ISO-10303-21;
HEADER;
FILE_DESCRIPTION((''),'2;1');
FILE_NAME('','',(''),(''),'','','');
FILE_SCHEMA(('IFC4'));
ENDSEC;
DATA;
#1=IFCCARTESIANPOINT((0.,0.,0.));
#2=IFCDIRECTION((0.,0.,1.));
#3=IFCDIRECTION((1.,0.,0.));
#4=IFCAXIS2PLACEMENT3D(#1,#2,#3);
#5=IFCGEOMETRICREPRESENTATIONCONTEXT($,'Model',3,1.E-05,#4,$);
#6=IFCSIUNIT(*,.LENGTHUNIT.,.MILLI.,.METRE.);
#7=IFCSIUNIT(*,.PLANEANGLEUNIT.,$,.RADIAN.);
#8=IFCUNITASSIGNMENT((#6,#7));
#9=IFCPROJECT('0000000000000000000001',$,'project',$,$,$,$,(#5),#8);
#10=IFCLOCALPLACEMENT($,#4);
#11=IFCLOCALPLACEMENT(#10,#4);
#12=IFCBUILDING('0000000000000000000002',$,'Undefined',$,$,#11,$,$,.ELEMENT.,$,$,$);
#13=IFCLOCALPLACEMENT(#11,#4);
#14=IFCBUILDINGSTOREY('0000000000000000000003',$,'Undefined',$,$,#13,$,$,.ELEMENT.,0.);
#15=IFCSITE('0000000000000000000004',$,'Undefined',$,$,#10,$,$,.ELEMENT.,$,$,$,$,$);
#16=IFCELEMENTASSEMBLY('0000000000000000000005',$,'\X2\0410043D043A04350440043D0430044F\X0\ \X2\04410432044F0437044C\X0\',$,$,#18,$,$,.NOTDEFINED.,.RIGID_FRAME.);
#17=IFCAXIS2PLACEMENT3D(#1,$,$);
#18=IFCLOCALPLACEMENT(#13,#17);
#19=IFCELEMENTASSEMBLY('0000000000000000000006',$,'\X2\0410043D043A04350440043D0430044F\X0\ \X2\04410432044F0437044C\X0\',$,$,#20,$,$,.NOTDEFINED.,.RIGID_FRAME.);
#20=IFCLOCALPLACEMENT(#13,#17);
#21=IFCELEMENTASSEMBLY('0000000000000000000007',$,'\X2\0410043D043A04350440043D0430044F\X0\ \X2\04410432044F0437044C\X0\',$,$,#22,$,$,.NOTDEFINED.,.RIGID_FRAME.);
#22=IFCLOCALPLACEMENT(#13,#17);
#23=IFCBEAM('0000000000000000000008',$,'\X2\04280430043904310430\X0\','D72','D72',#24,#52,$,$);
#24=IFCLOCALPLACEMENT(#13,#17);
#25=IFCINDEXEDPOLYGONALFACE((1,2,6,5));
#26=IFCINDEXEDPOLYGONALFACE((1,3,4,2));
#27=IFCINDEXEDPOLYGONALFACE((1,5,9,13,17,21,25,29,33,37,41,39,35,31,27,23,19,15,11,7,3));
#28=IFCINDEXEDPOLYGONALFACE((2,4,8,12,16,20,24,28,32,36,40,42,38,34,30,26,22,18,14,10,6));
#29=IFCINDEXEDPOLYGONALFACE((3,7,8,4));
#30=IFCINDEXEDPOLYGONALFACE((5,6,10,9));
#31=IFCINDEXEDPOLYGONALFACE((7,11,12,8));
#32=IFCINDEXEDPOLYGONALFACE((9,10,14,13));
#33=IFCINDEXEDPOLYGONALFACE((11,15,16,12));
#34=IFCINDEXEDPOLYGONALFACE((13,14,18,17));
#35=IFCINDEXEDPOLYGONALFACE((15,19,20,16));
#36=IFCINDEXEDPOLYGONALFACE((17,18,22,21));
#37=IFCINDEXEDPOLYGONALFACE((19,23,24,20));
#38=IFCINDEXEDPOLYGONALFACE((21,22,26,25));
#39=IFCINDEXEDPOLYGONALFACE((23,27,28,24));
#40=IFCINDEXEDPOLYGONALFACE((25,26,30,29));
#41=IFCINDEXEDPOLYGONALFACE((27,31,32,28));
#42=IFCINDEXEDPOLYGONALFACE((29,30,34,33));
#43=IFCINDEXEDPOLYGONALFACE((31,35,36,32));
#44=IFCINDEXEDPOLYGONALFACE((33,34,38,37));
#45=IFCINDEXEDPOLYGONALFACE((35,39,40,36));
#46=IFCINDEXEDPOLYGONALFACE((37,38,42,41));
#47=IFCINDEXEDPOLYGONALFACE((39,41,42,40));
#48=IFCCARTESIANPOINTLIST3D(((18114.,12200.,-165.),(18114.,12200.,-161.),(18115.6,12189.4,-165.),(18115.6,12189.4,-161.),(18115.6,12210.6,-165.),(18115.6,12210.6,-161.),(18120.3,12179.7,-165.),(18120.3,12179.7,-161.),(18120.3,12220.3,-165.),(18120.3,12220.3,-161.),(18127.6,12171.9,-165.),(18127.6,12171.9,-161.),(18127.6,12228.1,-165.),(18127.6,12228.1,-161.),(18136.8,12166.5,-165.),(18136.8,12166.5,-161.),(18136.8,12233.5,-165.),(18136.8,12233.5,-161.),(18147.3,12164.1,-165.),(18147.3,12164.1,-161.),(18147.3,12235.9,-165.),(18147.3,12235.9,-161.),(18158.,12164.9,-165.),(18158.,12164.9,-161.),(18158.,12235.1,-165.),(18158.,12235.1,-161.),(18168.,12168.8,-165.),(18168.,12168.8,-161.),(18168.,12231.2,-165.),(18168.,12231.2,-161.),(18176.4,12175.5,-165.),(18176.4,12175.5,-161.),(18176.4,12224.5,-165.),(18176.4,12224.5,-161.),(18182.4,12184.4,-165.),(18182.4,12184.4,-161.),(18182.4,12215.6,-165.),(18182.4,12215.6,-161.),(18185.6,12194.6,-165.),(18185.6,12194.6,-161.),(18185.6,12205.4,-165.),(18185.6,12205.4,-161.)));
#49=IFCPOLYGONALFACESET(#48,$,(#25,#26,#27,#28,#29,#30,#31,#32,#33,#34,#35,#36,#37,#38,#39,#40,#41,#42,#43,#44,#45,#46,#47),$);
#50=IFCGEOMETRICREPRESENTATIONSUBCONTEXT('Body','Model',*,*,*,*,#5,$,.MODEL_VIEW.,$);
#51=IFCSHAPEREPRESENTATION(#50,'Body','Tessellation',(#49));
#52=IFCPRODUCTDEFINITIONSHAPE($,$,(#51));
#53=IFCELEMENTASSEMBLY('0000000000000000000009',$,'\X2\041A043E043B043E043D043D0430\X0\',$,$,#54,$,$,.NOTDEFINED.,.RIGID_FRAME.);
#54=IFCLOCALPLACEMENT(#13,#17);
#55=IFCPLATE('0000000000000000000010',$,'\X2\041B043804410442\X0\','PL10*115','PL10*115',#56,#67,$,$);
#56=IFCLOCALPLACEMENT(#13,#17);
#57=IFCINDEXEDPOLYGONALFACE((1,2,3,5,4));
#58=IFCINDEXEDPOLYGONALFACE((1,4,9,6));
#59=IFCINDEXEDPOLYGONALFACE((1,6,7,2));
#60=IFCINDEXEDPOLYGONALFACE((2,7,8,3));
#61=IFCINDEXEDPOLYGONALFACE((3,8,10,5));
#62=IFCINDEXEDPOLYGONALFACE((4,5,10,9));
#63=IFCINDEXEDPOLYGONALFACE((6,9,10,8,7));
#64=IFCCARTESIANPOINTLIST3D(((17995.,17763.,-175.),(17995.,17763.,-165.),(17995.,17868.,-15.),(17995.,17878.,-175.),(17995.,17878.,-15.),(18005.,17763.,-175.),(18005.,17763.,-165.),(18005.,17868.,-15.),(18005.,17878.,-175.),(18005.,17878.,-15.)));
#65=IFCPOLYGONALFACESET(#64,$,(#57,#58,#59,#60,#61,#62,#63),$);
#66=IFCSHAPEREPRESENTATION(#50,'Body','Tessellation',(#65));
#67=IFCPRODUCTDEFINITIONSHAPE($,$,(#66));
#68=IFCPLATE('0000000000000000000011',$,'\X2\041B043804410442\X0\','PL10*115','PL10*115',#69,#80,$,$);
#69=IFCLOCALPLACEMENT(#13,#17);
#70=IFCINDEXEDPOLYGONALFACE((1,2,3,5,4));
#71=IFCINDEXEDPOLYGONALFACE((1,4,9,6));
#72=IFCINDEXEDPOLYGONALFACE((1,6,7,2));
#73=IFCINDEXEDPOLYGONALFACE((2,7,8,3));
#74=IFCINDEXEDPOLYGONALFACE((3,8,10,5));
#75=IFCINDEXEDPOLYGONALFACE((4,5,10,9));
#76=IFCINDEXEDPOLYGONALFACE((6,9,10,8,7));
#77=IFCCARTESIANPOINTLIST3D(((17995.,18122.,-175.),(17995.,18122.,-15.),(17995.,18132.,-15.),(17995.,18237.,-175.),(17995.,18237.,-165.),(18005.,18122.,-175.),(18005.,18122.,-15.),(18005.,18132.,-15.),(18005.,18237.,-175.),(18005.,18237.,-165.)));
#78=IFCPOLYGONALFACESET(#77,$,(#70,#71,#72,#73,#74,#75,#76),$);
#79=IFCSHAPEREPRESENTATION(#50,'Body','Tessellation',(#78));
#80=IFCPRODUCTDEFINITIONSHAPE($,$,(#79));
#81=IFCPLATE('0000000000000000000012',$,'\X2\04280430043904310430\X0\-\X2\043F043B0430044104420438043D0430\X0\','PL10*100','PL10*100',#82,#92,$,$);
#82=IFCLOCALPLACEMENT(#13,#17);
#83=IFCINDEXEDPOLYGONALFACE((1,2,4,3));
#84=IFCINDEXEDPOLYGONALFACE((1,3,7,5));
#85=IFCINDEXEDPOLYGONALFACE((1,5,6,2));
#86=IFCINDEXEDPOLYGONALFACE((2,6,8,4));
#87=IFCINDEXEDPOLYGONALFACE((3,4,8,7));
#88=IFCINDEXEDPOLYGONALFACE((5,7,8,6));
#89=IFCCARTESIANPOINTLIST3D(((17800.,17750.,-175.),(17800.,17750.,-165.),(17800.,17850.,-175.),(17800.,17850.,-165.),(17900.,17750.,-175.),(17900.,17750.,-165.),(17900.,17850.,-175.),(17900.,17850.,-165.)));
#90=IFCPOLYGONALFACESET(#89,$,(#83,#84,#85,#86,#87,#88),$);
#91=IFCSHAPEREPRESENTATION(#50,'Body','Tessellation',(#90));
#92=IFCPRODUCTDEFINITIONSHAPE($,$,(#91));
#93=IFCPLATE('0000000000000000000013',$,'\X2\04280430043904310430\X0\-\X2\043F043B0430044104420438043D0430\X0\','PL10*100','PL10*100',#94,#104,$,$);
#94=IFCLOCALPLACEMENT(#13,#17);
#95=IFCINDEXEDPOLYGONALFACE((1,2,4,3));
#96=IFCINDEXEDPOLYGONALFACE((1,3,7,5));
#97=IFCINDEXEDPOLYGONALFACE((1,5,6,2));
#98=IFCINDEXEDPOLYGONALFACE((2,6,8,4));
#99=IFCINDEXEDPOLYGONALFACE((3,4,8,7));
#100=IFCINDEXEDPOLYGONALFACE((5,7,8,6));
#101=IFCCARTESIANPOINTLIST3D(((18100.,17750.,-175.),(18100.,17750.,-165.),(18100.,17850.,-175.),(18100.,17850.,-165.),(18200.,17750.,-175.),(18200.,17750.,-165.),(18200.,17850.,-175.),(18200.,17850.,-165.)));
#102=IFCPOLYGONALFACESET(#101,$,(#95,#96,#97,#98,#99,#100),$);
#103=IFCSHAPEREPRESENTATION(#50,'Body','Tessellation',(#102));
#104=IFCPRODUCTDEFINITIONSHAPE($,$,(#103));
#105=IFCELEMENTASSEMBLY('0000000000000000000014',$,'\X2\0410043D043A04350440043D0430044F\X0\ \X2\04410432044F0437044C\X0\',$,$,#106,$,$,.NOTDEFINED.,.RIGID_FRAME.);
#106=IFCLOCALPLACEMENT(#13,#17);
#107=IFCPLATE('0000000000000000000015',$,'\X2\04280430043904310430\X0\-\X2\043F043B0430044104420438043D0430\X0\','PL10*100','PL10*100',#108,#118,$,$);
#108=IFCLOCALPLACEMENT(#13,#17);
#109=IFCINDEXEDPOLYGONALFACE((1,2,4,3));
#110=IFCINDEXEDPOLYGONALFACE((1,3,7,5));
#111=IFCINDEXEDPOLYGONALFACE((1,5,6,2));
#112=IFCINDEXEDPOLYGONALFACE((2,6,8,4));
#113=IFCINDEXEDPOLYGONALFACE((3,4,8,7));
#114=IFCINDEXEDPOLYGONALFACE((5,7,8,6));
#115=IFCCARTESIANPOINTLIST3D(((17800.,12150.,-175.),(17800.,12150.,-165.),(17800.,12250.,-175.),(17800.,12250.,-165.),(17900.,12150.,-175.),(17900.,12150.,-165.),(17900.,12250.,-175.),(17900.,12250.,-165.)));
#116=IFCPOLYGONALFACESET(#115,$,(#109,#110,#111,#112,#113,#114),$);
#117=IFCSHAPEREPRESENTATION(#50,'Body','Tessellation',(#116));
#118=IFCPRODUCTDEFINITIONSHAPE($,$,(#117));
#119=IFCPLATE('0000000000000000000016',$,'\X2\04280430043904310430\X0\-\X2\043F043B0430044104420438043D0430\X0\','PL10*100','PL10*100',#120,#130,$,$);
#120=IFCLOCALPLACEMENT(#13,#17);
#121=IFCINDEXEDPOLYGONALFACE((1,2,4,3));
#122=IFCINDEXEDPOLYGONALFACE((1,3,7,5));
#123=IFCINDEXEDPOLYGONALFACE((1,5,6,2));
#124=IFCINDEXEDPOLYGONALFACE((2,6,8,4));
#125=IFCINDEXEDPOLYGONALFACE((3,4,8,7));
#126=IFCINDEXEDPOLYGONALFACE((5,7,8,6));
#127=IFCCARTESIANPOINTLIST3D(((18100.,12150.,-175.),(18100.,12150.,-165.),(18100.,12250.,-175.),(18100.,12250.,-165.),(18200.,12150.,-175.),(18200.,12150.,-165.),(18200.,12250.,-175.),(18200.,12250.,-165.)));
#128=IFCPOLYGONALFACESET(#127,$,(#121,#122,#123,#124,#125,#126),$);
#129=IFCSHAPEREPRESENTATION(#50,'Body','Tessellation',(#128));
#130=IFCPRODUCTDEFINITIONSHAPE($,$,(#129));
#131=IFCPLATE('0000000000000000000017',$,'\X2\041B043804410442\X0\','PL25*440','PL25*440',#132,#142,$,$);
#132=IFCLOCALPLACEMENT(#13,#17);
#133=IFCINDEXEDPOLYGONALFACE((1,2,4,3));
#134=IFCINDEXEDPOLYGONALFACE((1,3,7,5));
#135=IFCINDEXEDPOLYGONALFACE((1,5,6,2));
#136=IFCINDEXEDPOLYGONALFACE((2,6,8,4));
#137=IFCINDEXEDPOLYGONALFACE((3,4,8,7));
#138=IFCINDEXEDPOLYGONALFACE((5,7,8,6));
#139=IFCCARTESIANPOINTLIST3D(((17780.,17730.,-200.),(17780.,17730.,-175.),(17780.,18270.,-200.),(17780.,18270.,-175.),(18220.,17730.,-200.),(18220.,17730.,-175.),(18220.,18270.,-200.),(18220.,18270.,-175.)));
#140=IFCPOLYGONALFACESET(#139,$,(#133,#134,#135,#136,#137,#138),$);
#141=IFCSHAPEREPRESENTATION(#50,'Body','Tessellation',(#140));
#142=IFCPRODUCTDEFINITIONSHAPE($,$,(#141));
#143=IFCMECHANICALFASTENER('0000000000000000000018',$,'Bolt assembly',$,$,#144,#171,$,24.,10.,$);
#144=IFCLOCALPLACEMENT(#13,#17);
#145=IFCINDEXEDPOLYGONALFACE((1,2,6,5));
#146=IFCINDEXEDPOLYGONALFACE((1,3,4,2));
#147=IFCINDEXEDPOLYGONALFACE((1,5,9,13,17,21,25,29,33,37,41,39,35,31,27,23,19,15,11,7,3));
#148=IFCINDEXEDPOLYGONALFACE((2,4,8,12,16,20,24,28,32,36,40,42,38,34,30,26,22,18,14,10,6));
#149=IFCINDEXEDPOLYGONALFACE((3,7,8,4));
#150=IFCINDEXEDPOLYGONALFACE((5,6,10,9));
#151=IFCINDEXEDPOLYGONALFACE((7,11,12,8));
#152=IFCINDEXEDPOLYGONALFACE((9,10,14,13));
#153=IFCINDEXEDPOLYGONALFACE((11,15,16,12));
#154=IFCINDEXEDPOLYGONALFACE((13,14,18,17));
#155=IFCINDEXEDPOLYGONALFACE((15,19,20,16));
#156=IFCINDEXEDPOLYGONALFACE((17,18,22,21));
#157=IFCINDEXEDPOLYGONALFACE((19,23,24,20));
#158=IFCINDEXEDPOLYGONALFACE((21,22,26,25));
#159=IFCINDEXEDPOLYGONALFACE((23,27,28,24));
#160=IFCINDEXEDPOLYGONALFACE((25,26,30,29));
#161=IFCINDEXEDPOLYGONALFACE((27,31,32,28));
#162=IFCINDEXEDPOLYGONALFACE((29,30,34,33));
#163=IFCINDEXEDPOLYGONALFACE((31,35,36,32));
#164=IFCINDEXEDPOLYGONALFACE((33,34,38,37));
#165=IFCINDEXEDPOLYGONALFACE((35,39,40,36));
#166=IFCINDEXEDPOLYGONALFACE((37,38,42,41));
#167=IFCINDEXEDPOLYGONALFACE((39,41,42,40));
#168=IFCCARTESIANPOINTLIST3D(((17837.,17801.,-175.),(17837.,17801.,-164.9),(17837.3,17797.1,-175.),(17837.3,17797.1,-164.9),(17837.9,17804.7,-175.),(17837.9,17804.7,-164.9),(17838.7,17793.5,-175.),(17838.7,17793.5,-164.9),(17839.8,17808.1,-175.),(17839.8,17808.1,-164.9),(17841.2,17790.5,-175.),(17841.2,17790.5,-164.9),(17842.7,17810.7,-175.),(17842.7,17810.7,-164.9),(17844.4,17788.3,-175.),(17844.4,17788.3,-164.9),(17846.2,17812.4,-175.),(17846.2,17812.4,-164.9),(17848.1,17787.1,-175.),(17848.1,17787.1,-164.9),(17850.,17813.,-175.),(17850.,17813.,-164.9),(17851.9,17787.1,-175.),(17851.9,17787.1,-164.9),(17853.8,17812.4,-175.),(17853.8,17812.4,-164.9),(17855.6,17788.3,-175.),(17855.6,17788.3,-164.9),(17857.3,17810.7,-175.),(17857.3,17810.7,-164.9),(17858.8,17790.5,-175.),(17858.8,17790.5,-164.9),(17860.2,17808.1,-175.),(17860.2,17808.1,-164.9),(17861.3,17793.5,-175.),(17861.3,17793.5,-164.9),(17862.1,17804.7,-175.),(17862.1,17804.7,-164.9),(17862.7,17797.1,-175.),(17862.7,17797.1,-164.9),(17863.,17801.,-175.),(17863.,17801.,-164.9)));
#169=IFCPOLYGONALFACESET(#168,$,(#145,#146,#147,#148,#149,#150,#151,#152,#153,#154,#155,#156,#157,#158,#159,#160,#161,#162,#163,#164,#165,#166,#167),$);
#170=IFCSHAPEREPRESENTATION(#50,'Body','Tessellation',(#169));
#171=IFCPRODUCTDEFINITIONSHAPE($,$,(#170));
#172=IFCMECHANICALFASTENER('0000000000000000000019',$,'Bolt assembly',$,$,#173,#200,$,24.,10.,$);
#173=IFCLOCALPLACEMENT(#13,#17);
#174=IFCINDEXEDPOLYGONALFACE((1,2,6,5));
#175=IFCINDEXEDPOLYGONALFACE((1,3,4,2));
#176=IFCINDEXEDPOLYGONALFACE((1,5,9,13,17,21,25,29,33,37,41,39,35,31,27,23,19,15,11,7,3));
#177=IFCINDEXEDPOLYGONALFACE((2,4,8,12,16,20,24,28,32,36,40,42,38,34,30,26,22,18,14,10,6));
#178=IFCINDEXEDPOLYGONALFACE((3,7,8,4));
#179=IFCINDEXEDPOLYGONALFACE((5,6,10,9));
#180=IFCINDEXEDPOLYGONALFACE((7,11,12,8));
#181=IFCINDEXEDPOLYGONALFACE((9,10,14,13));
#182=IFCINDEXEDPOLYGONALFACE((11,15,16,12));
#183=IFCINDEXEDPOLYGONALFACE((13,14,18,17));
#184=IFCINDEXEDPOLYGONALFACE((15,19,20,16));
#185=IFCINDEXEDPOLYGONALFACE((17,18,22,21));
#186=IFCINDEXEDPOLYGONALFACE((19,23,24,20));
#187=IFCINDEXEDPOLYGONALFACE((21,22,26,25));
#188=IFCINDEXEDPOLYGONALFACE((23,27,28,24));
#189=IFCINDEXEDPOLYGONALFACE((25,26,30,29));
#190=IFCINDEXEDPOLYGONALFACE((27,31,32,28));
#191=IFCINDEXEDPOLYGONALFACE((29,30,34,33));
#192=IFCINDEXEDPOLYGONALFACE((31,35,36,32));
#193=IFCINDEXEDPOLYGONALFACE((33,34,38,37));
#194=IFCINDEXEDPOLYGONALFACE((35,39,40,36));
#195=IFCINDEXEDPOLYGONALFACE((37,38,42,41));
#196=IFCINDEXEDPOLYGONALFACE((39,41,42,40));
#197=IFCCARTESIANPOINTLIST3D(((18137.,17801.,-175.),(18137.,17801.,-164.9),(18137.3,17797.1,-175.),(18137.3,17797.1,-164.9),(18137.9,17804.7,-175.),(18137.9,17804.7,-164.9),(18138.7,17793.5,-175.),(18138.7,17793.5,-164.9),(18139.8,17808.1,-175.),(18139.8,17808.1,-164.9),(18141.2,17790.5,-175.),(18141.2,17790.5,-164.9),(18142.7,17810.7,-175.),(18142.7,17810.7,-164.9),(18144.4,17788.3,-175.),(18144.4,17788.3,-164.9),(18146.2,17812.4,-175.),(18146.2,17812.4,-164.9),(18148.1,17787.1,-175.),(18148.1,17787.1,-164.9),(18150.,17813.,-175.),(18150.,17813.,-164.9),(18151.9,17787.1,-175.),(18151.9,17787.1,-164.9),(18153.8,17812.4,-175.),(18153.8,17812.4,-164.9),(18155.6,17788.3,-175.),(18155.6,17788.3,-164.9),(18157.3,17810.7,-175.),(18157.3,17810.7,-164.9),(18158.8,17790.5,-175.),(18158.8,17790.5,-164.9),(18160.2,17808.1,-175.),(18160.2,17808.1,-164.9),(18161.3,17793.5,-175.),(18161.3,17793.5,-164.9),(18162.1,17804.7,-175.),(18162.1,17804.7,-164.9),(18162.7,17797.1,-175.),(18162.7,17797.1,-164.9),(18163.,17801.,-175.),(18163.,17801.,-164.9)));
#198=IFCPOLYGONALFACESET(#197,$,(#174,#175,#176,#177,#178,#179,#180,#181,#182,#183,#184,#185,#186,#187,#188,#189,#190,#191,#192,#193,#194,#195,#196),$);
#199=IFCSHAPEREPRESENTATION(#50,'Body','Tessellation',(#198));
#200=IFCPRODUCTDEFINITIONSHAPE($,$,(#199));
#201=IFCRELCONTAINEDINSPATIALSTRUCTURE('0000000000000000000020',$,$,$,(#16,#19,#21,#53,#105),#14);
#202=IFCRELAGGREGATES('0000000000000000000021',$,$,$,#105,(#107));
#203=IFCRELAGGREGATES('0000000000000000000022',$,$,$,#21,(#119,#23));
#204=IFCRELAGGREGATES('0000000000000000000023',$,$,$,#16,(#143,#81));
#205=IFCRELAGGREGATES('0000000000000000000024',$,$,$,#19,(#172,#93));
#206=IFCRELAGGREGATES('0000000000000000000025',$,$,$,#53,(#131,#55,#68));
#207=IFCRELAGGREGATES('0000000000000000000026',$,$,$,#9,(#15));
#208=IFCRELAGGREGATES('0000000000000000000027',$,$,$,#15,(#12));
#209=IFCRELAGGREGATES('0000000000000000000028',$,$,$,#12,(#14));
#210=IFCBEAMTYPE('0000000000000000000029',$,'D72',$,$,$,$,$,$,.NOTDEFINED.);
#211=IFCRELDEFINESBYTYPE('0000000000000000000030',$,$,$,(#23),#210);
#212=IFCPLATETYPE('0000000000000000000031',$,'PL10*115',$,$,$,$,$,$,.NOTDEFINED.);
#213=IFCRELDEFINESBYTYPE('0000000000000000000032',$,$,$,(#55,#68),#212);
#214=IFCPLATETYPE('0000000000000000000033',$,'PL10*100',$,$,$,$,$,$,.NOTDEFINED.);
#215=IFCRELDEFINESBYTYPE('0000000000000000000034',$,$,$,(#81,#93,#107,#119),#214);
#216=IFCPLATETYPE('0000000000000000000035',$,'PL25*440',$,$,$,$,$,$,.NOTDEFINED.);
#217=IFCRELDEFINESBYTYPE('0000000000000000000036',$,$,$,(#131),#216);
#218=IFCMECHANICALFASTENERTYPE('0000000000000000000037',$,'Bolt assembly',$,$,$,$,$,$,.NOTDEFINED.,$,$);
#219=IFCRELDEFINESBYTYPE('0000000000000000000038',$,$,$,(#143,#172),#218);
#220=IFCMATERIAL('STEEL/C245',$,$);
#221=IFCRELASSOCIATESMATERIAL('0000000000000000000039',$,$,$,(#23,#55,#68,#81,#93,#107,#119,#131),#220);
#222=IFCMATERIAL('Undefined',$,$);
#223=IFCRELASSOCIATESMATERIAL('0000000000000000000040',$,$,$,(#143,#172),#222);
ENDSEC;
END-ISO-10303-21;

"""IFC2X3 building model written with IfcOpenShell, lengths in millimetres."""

from ifc_helpers import new_model, si_unit, frame, origin_with_axes, origin_2d_with_axis, place, context, subcontext, project, spatial, polyline, circle, outline, extrude, source, transform, mapped, material, type_object, element, aggregate, save


model = new_model("IFC2X3")

# Units and contexts
model_context = context("Model", 3, precision=1e-05, world=origin_with_axes())
body_context = subcontext(model_context, "Body", "Model", "MODEL_VIEW")
ifc_project = project(units=[si_unit("LENGTHUNIT", "METRE", prefix="MILLI"), si_unit("PLANEANGLEUNIT", "RADIAN")], contexts=[model_context])

# Site, building, storey
site_placement = place(None, origin_with_axes())
site = spatial("IfcSite", under=ifc_project, at=site_placement, Name="Undefined", CompositionType="ELEMENT")
building_placement = place(site_placement, origin_with_axes())
building = spatial("IfcBuilding", under=site, at=building_placement, Name="Undefined", CompositionType="ELEMENT")
storey_placement = place(building_placement, origin_with_axes())
storey = spatial("IfcBuildingStorey", under=building, at=storey_placement, Name="Undefined", CompositionType="ELEMENT", Elevation=0.0)

# Element assemblies
assembly_1_placement = place(storey_placement, origin_with_axes())
assembly_1 = element("IfcElementAssembly", 1, at=assembly_1_placement, inside=storey, Name="Анкерная связь", AssemblyPlace="NOTDEFINED", PredefinedType="RIGID_FRAME")
ifc_material_1 = material(Name="STEEL/C245")
assembly_2_placement = place(storey_placement, origin_with_axes())
assembly_2 = element("IfcElementAssembly", 2, at=assembly_2_placement, inside=storey, Name="Анкерная связь", AssemblyPlace="NOTDEFINED", PredefinedType="RIGID_FRAME")

# Element assembly
assembly_3_placement = place(storey_placement, origin_with_axes())
assembly_3 = element("IfcElementAssembly", 3, at=assembly_3_placement, inside=storey, Name="Анкерная связь", AssemblyPlace="NOTDEFINED", PredefinedType="RIGID_FRAME")

# Beam
beam_type_1 = type_object("IfcBeamType", Name="D72", PredefinedType="NOTDEFINED")
beam_1_placement = place(assembly_3_placement, frame((18150.0, 12200.0, -161.0), z_axis=(0.0, -1.0, 0.0), x_axis=(0.0, 0.0, -1.0)))
beam_1 = element("IfcBeam", 4, at=beam_1_placement, type_object=beam_type_1, material=ifc_material_1, Name="Шайба", Description="D72", ObjectType="D72", context=body_context, shape_type="SweptSolid", body=[
    extrude(circle(Radius=36.0, at=origin_2d_with_axis()), frame((4.0, 0.0, 0.0), z_axis=(-1.0, 0.0, 0.0), x_axis=(0.0, -1.0, 0.0)), (0.0, 0.0, 1.0), 4.0),
])

# Element assembly, plates
assembly_4_placement = place(storey_placement, origin_with_axes())
assembly_4 = element("IfcElementAssembly", 5, at=assembly_4_placement, inside=storey, Name="Колонна", AssemblyPlace="NOTDEFINED", PredefinedType="RIGID_FRAME")
plate_type_1 = type_object("IfcPlateType", Name="PL10*115", PredefinedType="NOTDEFINED")
plate_1_placement = place(assembly_4_placement, frame((18000.0, 17878.0, -15.0), z_axis=(-1.0, 0.0, 0.0), x_axis=(0.0, 0.0, -1.0)))
plate_1 = element("IfcPlate", 6, at=plate_1_placement, type_object=plate_type_1, material=ifc_material_1, Name="Лист", Description="PL10*115", ObjectType="PL10*115", context=body_context, shape_type="SweptSolid", body=[
    extrude(outline(polyline([(0.0, 0.0), (160.0, 0.0), (160.0, 115.0), (150.0, 115.0), (0.0, 10.0), (0.0, 0.0)])), frame((0.0, 0.0, -5.0), z_axis=(0.0, 0.0, 1.0), x_axis=(1.0, 0.0, 0.0)), (0.0, 0.0, 1.0), 10.0),
])
plate_2_placement = place(assembly_4_placement, frame((18000.0, 18122.0, -15.0), z_axis=(1.0, 0.0, 0.0), x_axis=(0.0, 0.0, -1.0)))
plate_2 = element("IfcPlate", 7, at=plate_2_placement, type_object=plate_type_1, material=ifc_material_1, Name="Лист", Description="PL10*115", ObjectType="PL10*115", context=body_context, shape_type="SweptSolid", body=[
    extrude(outline(polyline([(0.0, 0.0), (160.0, 0.0), (160.0, 115.0), (150.0, 115.0), (0.0, 10.0), (0.0, 0.0)])), frame((0.0, 0.0, -5.0), z_axis=(0.0, 0.0, 1.0), x_axis=(1.0, 0.0, 0.0)), (0.0, 0.0, 1.0), 10.0),
])

# Plates
plate_type_2 = type_object("IfcPlateType", Name="PL10*100", PredefinedType="NOTDEFINED")
plate_3_placement = place(assembly_1_placement, frame((17900.0, 17850.0, -170.0), z_axis=(0.0, 0.0, -1.0), x_axis=(0.0, -1.0, 0.0)))
plate_3 = element("IfcPlate", 8, at=plate_3_placement, type_object=plate_type_2, material=ifc_material_1, Name="Шайба-пластина", Description="PL10*100", ObjectType="PL10*100", context=body_context, shape_type="SweptSolid", body=[
    extrude(outline(polyline([(0.0, 0.0), (100.0, 0.0), (100.0, 100.0), (0.0, 100.0), (0.0, 0.0)])), frame((0.0, 0.0, -5.0), z_axis=(0.0, 0.0, 1.0), x_axis=(1.0, 0.0, 0.0)), (0.0, 0.0, 1.0), 10.0),
])
plate_4_placement = place(assembly_2_placement, frame((18200.0, 17850.0, -170.0), z_axis=(0.0, 0.0, -1.0), x_axis=(0.0, -1.0, 0.0)))
plate_4 = element("IfcPlate", 9, at=plate_4_placement, type_object=plate_type_2, material=ifc_material_1, Name="Шайба-пластина", Description="PL10*100", ObjectType="PL10*100", context=body_context, shape_type="SweptSolid", body=[
    extrude(outline(polyline([(0.0, 0.0), (100.0, 0.0), (100.0, 100.0), (0.0, 100.0), (0.0, 0.0)])), frame((0.0, 0.0, -5.0), z_axis=(0.0, 0.0, 1.0), x_axis=(1.0, 0.0, 0.0)), (0.0, 0.0, 1.0), 10.0),
])

# Element assembly, plate
assembly_5_placement = place(storey_placement, origin_with_axes())
assembly_5 = element("IfcElementAssembly", 10, at=assembly_5_placement, inside=storey, Name="Анкерная связь", AssemblyPlace="NOTDEFINED", PredefinedType="RIGID_FRAME")
plate_5_placement = place(assembly_5_placement, frame((17900.0, 12250.0, -170.0), z_axis=(0.0, 0.0, -1.0), x_axis=(0.0, -1.0, 0.0)))
plate_5 = element("IfcPlate", 11, at=plate_5_placement, type_object=plate_type_2, material=ifc_material_1, Name="Шайба-пластина", Description="PL10*100", ObjectType="PL10*100", context=body_context, shape_type="SweptSolid", body=[
    extrude(outline(polyline([(0.0, 0.0), (100.0, 0.0), (100.0, 100.0), (0.0, 100.0), (0.0, 0.0)])), frame((0.0, 0.0, -5.0), z_axis=(0.0, 0.0, 1.0), x_axis=(1.0, 0.0, 0.0)), (0.0, 0.0, 1.0), 10.0),
])
aggregate(assembly_5, [plate_5])

# Plates
plate_6_placement = place(assembly_3_placement, frame((18200.0, 12250.0, -170.0), z_axis=(0.0, 0.0, -1.0), x_axis=(0.0, -1.0, 0.0)))
plate_6 = element("IfcPlate", 12, at=plate_6_placement, type_object=plate_type_2, material=ifc_material_1, Name="Шайба-пластина", Description="PL10*100", ObjectType="PL10*100", context=body_context, shape_type="SweptSolid", body=[
    extrude(outline(polyline([(0.0, 0.0), (100.0, 0.0), (100.0, 100.0), (0.0, 100.0), (0.0, 0.0)])), frame((0.0, 0.0, -5.0), z_axis=(0.0, 0.0, 1.0), x_axis=(1.0, 0.0, 0.0)), (0.0, 0.0, 1.0), 10.0),
])
aggregate(assembly_3, [plate_6, beam_1])
plate_type_3 = type_object("IfcPlateType", Name="PL25*440", PredefinedType="NOTDEFINED")
plate_7_placement = place(assembly_4_placement, frame((18000.0, 17730.0, -187.5), z_axis=(0.0, 0.0, 1.0), x_axis=(0.0, 1.0, 0.0)))
plate_7 = element("IfcPlate", 13, at=plate_7_placement, type_object=plate_type_3, material=ifc_material_1, Name="Лист", Description="PL25*440", ObjectType="PL25*440", context=body_context, shape_type="SweptSolid", body=[
    extrude(outline(polyline([(0.0, 220.0), (540.0, 220.0), (540.0, -220.0), (0.0, -220.0), (0.0, 220.0)])), frame((0.0, 0.0, -12.5), z_axis=(0.0, 0.0, 1.0), x_axis=(1.0, 0.0, 0.0)), (0.0, 0.0, 1.0), 25.0),
])

# Mechanical fasteners
ifc_material_2 = material(Name="Undefined")
mechanical_fastener_type = type_object("IfcMechanicalFastenerType", Name="Bolt assembly")
shared_shape_1 = source(origin_with_axes(), body_context, "Body", "SweptSolid", [
    extrude(circle(Radius=13.0, at=origin_2d_with_axis()), frame((0.0, 0.0, 0.0), z_axis=(0.0, 1.0, 0.0), x_axis=(1.0, 0.0, 0.0)), (0.0, 0.0, 1.0), 10.1),
])
mechanical_fastener_1_placement = place(assembly_1_placement, frame((17850.0, 17800.0, -175.0), z_axis=(1.0, 0.0, 0.0), x_axis=(0.0, 1.0, 0.0)))
mechanical_fastener_1 = element("IfcMechanicalFastener", 14, at=mechanical_fastener_1_placement, type_object=mechanical_fastener_type, material=ifc_material_2, Name="Bolt assembly", NominalDiameter=24.0, NominalLength=10.0, context=body_context, shape_type="MappedRepresentation", body=[
    mapped(shared_shape_1, transform((0.0, 0.0, 0.0))),
])
mechanical_fastener_2_placement = place(assembly_2_placement, frame((18150.0, 17800.0, -175.0), z_axis=(1.0, 0.0, 0.0), x_axis=(0.0, 1.0, 0.0)))
mechanical_fastener_2 = element("IfcMechanicalFastener", 15, at=mechanical_fastener_2_placement, type_object=mechanical_fastener_type, material=ifc_material_2, Name="Bolt assembly", NominalDiameter=24.0, NominalLength=10.0, context=body_context, shape_type="MappedRepresentation", body=[
    mapped(shared_shape_1, transform((0.0, 0.0, 0.0))),
])
aggregate(assembly_1, [mechanical_fastener_1, plate_3])
aggregate(assembly_2, [mechanical_fastener_2, plate_4])
aggregate(assembly_4, [plate_7, plate_1, plate_2])

save(model, "model.ifc")
